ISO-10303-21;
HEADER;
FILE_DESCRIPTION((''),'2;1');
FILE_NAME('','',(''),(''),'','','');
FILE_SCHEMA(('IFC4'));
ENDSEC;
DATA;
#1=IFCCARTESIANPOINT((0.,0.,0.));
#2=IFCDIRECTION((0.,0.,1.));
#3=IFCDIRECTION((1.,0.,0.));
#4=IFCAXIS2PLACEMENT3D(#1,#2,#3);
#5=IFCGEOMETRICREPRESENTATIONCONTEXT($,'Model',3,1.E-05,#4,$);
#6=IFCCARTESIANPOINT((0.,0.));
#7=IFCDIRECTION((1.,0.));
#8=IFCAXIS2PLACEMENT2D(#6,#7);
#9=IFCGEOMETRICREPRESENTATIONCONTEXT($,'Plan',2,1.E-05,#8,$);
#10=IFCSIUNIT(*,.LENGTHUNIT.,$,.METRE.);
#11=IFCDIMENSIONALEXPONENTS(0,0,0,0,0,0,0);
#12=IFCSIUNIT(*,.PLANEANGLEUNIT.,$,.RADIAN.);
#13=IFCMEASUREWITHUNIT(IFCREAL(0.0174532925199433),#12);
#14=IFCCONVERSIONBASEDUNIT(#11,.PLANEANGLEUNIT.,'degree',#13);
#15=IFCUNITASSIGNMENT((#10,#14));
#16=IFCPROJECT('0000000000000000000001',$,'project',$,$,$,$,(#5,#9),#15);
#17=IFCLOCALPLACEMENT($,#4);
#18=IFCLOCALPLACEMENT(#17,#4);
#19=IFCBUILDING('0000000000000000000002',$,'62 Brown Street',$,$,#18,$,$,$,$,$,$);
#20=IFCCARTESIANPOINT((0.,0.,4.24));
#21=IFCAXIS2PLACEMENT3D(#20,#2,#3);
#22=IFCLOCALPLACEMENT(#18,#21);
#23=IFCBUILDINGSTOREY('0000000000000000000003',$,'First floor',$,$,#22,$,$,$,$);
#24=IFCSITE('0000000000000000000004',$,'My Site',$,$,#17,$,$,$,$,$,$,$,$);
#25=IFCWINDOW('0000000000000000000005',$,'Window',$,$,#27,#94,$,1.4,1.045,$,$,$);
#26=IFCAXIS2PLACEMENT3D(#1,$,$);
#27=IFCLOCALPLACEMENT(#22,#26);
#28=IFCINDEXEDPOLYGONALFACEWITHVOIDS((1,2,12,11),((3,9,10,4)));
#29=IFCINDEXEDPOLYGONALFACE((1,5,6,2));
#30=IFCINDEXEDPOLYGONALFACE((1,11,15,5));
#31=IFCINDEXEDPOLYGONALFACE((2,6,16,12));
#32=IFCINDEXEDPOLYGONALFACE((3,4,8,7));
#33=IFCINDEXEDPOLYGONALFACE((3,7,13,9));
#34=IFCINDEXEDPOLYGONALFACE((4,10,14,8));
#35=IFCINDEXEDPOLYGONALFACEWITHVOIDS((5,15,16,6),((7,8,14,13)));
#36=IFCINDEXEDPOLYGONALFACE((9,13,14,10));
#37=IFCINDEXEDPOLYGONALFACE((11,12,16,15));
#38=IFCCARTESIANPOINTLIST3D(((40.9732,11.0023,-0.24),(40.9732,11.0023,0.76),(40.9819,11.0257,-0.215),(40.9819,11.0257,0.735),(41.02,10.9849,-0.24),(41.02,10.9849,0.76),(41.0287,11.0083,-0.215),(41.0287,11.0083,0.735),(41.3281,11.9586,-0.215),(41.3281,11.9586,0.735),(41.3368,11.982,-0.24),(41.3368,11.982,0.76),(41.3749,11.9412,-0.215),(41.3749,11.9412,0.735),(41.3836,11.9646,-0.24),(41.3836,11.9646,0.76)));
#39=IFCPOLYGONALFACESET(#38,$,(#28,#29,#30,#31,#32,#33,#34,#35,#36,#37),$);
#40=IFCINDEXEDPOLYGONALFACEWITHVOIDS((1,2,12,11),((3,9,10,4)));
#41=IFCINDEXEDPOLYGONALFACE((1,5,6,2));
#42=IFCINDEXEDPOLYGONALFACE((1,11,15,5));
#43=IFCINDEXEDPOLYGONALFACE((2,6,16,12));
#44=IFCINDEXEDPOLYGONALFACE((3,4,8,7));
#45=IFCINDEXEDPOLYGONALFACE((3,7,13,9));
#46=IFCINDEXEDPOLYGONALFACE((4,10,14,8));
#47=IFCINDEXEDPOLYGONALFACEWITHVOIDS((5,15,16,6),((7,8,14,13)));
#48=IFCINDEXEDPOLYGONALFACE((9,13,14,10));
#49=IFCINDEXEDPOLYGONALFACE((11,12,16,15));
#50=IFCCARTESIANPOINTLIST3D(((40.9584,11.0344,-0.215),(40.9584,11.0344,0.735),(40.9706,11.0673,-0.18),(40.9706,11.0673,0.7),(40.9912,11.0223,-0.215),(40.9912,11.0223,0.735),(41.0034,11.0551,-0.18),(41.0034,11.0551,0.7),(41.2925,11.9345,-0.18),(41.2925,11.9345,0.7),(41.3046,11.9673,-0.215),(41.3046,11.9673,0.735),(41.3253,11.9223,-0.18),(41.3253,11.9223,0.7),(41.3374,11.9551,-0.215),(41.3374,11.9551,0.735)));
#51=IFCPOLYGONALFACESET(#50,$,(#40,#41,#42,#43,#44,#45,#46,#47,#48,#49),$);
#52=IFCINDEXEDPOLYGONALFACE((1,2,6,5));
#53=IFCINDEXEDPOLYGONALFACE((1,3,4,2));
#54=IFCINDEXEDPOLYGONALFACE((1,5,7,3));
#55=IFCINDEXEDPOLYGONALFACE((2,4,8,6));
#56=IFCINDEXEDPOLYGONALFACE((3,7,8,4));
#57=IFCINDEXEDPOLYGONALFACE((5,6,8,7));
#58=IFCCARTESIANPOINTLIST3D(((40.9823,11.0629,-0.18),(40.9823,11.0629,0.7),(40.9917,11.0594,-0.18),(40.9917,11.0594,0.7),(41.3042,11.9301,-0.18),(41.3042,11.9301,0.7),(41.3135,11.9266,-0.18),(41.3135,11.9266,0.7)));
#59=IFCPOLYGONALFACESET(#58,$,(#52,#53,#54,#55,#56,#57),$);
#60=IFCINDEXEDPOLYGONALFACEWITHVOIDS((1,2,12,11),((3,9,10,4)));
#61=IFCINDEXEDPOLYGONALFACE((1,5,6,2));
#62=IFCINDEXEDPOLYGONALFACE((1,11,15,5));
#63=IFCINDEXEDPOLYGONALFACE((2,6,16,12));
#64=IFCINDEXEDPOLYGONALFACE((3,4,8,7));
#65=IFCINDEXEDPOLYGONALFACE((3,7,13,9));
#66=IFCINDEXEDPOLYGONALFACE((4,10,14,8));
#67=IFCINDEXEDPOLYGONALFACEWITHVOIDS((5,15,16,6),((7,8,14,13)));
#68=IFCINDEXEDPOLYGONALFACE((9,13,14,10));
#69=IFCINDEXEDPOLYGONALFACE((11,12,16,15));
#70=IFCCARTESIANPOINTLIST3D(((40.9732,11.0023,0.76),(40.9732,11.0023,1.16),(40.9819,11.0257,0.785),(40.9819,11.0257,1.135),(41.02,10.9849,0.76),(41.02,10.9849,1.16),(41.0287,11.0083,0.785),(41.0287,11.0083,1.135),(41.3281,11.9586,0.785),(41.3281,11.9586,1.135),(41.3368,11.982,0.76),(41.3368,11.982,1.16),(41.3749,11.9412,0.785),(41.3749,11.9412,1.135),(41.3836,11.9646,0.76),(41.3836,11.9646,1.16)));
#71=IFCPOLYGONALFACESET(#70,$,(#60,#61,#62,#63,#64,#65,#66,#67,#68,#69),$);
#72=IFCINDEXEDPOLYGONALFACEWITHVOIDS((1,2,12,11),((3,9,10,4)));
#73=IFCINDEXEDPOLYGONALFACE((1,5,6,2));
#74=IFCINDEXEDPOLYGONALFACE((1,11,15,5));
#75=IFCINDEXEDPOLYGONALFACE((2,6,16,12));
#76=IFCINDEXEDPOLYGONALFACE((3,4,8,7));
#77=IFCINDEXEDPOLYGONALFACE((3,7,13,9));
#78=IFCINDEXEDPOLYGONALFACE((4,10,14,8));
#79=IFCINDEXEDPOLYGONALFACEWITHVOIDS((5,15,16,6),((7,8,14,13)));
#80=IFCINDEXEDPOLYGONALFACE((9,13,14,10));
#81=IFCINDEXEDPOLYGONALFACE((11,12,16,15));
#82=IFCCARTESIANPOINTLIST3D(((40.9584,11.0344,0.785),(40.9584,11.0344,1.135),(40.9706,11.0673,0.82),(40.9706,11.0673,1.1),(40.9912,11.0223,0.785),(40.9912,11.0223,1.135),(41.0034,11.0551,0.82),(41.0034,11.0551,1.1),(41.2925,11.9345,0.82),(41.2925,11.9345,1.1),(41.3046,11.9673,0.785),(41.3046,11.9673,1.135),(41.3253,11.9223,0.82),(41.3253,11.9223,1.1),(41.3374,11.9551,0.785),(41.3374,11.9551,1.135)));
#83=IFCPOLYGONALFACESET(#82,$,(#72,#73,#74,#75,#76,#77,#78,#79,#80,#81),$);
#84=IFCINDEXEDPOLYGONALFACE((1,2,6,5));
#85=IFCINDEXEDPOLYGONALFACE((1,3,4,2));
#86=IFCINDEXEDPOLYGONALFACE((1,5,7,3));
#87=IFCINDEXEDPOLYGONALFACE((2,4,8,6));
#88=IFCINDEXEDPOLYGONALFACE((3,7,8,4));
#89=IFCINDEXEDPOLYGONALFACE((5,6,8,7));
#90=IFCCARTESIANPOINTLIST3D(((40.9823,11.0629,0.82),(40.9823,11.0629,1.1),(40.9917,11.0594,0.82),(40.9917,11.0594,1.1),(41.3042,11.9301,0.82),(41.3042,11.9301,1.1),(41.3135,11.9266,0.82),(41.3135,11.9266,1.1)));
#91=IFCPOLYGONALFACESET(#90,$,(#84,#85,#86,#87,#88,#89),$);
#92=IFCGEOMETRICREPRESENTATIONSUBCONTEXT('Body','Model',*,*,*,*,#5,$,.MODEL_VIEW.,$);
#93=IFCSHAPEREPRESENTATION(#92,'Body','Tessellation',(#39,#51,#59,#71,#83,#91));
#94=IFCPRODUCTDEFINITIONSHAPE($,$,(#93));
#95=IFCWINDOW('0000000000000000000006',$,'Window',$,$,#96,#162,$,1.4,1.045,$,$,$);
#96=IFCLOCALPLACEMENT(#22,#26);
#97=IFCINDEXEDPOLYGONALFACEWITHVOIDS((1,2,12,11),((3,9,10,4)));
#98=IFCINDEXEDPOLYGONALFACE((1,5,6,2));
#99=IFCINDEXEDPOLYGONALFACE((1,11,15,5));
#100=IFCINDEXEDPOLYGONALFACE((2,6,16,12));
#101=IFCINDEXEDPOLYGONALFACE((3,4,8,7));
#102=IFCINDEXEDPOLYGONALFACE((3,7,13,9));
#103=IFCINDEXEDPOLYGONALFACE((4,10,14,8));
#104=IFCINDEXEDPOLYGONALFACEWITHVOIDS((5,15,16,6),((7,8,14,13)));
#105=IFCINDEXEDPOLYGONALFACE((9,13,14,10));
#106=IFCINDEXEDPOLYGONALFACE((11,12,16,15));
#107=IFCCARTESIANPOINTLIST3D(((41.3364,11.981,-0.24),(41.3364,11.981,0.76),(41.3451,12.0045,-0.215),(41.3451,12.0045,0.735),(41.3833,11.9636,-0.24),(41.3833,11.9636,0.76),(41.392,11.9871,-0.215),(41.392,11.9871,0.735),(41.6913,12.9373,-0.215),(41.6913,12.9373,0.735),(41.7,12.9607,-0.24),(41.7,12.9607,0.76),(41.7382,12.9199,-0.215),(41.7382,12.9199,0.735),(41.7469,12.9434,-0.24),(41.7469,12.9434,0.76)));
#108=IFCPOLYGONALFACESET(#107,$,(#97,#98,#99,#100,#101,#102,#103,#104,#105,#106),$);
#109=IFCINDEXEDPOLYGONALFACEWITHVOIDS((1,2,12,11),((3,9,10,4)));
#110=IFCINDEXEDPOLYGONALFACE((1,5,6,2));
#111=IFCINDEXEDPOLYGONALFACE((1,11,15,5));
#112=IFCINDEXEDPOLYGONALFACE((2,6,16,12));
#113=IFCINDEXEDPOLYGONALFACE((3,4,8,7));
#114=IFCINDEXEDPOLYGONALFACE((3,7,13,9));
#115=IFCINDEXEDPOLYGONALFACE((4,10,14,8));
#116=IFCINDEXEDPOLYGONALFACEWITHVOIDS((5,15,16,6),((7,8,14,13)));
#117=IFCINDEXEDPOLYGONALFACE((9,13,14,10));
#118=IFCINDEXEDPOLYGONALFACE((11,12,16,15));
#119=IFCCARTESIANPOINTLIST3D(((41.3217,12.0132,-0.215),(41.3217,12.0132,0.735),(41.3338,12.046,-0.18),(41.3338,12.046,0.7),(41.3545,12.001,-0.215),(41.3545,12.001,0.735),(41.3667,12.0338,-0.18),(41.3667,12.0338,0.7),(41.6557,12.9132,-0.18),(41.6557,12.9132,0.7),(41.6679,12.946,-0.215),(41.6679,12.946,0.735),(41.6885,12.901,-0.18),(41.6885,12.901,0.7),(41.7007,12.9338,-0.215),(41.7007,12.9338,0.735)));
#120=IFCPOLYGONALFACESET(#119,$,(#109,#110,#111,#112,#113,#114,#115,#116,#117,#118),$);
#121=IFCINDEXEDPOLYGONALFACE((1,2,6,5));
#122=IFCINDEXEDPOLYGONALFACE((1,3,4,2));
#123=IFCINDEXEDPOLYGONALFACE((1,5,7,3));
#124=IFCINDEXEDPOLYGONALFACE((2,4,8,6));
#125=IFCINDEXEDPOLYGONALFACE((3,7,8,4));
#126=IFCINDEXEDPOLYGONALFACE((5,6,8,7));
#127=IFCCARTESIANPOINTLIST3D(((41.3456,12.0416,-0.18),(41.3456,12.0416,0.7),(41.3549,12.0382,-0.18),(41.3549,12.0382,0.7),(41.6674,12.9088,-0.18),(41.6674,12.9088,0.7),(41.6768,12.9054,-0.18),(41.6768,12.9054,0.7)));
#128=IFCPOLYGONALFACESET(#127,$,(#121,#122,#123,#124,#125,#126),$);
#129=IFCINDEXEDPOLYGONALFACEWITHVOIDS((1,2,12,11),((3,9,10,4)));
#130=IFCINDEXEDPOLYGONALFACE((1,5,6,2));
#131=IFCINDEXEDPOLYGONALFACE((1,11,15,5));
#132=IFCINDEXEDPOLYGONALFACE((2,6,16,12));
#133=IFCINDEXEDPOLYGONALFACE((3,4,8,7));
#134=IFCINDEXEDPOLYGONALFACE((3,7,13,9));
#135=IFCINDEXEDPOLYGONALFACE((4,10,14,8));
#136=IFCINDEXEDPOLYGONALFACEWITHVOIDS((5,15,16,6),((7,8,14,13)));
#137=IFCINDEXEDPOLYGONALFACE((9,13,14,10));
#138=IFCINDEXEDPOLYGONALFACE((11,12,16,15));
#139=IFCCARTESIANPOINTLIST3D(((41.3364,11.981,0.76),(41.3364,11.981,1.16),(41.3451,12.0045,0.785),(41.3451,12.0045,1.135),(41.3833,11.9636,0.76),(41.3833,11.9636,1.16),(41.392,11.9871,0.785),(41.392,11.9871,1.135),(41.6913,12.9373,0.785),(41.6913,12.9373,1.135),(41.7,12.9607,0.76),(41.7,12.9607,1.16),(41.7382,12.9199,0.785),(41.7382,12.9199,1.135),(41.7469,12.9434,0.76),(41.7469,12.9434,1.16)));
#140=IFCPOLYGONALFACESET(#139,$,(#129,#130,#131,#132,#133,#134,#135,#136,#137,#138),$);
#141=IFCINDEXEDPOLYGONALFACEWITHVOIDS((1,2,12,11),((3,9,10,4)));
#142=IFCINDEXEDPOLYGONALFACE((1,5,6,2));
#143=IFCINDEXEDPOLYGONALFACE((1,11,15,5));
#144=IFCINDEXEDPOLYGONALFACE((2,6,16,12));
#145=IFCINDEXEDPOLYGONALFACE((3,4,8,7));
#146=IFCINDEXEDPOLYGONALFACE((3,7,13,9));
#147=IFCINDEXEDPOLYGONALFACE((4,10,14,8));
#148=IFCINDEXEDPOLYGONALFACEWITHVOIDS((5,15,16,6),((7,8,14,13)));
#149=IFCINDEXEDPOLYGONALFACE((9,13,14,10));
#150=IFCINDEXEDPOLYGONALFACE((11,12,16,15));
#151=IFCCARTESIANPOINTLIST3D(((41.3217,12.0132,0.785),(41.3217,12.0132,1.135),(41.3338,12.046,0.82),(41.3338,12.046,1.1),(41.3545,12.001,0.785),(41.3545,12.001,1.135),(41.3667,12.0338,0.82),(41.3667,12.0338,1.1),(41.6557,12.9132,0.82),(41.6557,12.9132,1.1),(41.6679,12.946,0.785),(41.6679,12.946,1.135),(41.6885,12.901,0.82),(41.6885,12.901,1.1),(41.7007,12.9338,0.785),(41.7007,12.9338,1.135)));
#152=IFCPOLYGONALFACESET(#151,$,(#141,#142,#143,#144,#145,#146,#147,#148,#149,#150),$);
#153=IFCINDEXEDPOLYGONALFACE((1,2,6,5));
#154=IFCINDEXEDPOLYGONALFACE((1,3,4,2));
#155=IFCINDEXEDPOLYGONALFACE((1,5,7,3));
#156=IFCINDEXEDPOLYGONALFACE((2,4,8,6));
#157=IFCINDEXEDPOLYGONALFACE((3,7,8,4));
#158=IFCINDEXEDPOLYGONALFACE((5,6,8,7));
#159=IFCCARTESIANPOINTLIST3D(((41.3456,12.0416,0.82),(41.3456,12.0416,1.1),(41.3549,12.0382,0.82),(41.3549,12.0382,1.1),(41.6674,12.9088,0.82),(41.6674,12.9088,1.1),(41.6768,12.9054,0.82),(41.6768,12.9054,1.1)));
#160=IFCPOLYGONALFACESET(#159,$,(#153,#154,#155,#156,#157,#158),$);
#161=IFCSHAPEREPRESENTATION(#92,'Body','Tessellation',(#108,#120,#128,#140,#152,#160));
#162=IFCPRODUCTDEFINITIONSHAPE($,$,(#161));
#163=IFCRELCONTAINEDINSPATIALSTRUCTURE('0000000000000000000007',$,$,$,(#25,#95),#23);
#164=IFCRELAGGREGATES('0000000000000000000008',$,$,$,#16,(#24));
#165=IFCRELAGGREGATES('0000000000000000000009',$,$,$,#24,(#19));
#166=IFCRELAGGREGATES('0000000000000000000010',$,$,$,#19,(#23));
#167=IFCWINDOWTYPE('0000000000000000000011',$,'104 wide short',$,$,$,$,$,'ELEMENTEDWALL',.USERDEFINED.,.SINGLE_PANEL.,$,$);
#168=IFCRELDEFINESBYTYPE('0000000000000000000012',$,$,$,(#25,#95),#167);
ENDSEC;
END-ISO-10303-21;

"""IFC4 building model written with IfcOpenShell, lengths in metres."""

from ifc_helpers import new_model, entity, si_unit, converted_unit, frame, origin_with_axes, origin_2d_with_axis, place, context, subcontext, project, spatial, line, indexed_curve, outline, extrude, shape, source, transform, mapped, type_object, type_shapes, element, save


model = new_model("IFC4")

# Units and contexts
model_context = context("Model", 3, precision=1e-05, world=origin_with_axes())
plan_context = context("Plan", 2, precision=1e-05, world=origin_2d_with_axis())
body_context_1 = subcontext(model_context, "Body", "Model", "MODEL_VIEW")
body_context_2 = subcontext(plan_context, "Body", "Plan", "PLAN_VIEW")
ifc_project = project(units=[si_unit("LENGTHUNIT", "METRE"), converted_unit("PLANEANGLEUNIT", "degree", entity("IfcReal", 0.0174532925199433), si_unit("PLANEANGLEUNIT", "RADIAN"), dimensions=[0, 0, 0, 0, 0, 0, 0])], contexts=[model_context, plan_context])

# Site, building, storey
site_placement = place(None, origin_with_axes())
site = spatial("IfcSite", under=ifc_project, at=site_placement, Name="My Site")
building_placement = place(site_placement, origin_with_axes())
building = spatial("IfcBuilding", under=site, at=building_placement, Name="62 Brown Street")
storey_placement = place(building_placement, frame((0.0, 0.0, 4.24), z_axis=(0.0, 0.0, 1.0), x_axis=(1.0, 0.0, 0.0)))
storey = spatial("IfcBuildingStorey", under=building, at=storey_placement, Name="First floor")

# Shared definitions
window_type_1 = type_object("IfcWindowType", Name="104 wide short", ElementType="ELEMENTEDWALL", PartitioningType="SINGLE_PANEL", PredefinedType="USERDEFINED")
shared_shape_1 = source(origin_with_axes(), body_context_1, "Body", "SweptSolid", [
    extrude(outline(indexed_curve([(0.0, 0.0), (1.045, 0.0), (1.045, 1.0), (0.0, 1.0)], segments=[line(1, 2, 3, 4, 1)]), holes=[indexed_curve([(0.025, 0.025), (1.02, 0.025), (1.02, 0.975), (0.025, 0.975)], segments=[line(1, 2, 3, 4, 1)])]), frame((0.0, 0.15, 0.0), z_axis=(0.0, -1.0, 0.0), x_axis=(1.0, 0.0, 0.0)), (0.0, 0.0, -1.0), 0.05),
    extrude(outline(indexed_curve([(0.0, 0.0), (0.995, 0.0), (0.995, 0.95), (0.0, 0.95)], segments=[line(1, 2, 3, 4, 1)]), holes=[indexed_curve([(0.035, 0.035), (0.96, 0.035), (0.96, 0.915), (0.035, 0.915)], segments=[line(1, 2, 3, 4, 1)])]), frame((0.025, 0.19, 0.025), z_axis=(0.0, -1.0, 0.0), x_axis=(1.0, 0.0, 0.0)), (0.0, 0.0, -1.0), 0.035),
    extrude(outline(indexed_curve([(0.035, 0.035), (0.96, 0.035), (0.96, 0.915), (0.035, 0.915)], segments=[line(1, 2, 3, 4, 1)])), frame((0.025, 0.2025, 0.025), z_axis=(0.0, -1.0, 0.0), x_axis=(1.0, 0.0, 0.0)), (0.0, 0.0, -1.0), 0.01),
    extrude(outline(indexed_curve([(0.0, 0.0), (1.045, 0.0), (1.045, 0.4), (0.0, 0.4)], segments=[line(1, 2, 3, 4, 1)]), holes=[indexed_curve([(0.025, 0.025), (1.02, 0.025), (1.02, 0.375), (0.025, 0.375)], segments=[line(1, 2, 3, 4, 1)])]), frame((0.0, 0.15, 1.0), z_axis=(0.0, -1.0, 0.0), x_axis=(1.0, 0.0, 0.0)), (0.0, 0.0, -1.0), 0.05),
    extrude(outline(indexed_curve([(0.0, 0.0), (0.995, 0.0), (0.995, 0.35), (0.0, 0.35)], segments=[line(1, 2, 3, 4, 1)]), holes=[indexed_curve([(0.035, 0.035), (0.96, 0.035), (0.96, 0.315), (0.035, 0.315)], segments=[line(1, 2, 3, 4, 1)])]), frame((0.025, 0.19, 1.025), z_axis=(0.0, -1.0, 0.0), x_axis=(1.0, 0.0, 0.0)), (0.0, 0.0, -1.0), 0.035),
    extrude(outline(indexed_curve([(0.035, 0.035), (0.96, 0.035), (0.96, 0.315), (0.035, 0.315)], segments=[line(1, 2, 3, 4, 1)])), frame((0.025, 0.2025, 1.025), z_axis=(0.0, -1.0, 0.0), x_axis=(1.0, 0.0, 0.0)), (0.0, 0.0, -1.0), 0.01),
])
shared_shape_2 = source(origin_with_axes(), body_context_2, "Body", "Curve2D", [
    entity("IfcIndexedPolyCurve", entity("IfcCartesianPointList2D", [[0.025, 0.15], [1.02, 0.15]])),
    entity("IfcIndexedPolyCurve", entity("IfcCartesianPointList2D", [[0.0, 0.2], [0.025, 0.2], [0.025, 0.15], [0.0, 0.15]]), [entity("IfcLineIndex", [1, 2, 3, 4, 1])]),
    entity("IfcIndexedPolyCurve", entity("IfcCartesianPointList2D", [[1.045, 0.2], [1.02, 0.2], [1.02, 0.15], [1.045, 0.15]]), [entity("IfcLineIndex", [1, 2, 3, 4, 1])]),
    entity("IfcIndexedPolyCurve", entity("IfcCartesianPointList2D", [[0.025, 0.19], [0.06, 0.19], [0.06, 0.225], [0.025, 0.225]]), [entity("IfcLineIndex", [1, 2, 3, 4, 1])]),
    entity("IfcIndexedPolyCurve", entity("IfcCartesianPointList2D", [[1.02, 0.19], [0.985, 0.19], [0.985, 0.225], [1.02, 0.225]]), [entity("IfcLineIndex", [1, 2, 3, 4, 1])]),
    entity("IfcIndexedPolyCurve", entity("IfcCartesianPointList2D", [[0.06, 0.19], [0.985, 0.19]])),
    entity("IfcIndexedPolyCurve", entity("IfcCartesianPointList2D", [[0.06, 0.225], [0.985, 0.225]])),
    entity("IfcIndexedPolyCurve", entity("IfcCartesianPointList2D", [[0.06, 0.2075], [0.985, 0.2075]])),
])
type_shapes(window_type_1, [shared_shape_1, shared_shape_2])

# Windows
for number, where, z_axis, x_axis, name in (
    (1, (41.1607, 10.9327, -0.24), (0.0, 0.0, 1.0), (0.347944, 0.937515, 0.0), "Window"),
    (2, (41.5239, 11.9115, -0.24), (0.0, 0.0, 1.0), (0.347944, 0.937515, 0.0), "Window"),
):
    element("IfcWindow", number, at=place(storey_placement, frame(where, z_axis=z_axis, x_axis=x_axis)), inside=storey, type_object=window_type_1, Name=name, OverallHeight=1.4, OverallWidth=1.045, shapes=[
        shape(body_context_1, "Body", "MappedRepresentation", [mapped(shared_shape_1, transform((0.0, 0.0, 0.0), x_axis=(1.0, 0.0, 0.0), y_axis=(0.0, 1.0, 0.0), z_axis=(0.0, 0.0, 1.0), scale=1.0))]),
        shape(body_context_2, "Body", "MappedRepresentation", [mapped(shared_shape_2, transform((0.0, 0.0, 0.0), x_axis=(1.0, 0.0, 0.0), y_axis=(0.0, 1.0, 0.0), z_axis=(0.0, 0.0, 1.0), scale=1.0))]),
    ])

save(model, "model.ifc")
